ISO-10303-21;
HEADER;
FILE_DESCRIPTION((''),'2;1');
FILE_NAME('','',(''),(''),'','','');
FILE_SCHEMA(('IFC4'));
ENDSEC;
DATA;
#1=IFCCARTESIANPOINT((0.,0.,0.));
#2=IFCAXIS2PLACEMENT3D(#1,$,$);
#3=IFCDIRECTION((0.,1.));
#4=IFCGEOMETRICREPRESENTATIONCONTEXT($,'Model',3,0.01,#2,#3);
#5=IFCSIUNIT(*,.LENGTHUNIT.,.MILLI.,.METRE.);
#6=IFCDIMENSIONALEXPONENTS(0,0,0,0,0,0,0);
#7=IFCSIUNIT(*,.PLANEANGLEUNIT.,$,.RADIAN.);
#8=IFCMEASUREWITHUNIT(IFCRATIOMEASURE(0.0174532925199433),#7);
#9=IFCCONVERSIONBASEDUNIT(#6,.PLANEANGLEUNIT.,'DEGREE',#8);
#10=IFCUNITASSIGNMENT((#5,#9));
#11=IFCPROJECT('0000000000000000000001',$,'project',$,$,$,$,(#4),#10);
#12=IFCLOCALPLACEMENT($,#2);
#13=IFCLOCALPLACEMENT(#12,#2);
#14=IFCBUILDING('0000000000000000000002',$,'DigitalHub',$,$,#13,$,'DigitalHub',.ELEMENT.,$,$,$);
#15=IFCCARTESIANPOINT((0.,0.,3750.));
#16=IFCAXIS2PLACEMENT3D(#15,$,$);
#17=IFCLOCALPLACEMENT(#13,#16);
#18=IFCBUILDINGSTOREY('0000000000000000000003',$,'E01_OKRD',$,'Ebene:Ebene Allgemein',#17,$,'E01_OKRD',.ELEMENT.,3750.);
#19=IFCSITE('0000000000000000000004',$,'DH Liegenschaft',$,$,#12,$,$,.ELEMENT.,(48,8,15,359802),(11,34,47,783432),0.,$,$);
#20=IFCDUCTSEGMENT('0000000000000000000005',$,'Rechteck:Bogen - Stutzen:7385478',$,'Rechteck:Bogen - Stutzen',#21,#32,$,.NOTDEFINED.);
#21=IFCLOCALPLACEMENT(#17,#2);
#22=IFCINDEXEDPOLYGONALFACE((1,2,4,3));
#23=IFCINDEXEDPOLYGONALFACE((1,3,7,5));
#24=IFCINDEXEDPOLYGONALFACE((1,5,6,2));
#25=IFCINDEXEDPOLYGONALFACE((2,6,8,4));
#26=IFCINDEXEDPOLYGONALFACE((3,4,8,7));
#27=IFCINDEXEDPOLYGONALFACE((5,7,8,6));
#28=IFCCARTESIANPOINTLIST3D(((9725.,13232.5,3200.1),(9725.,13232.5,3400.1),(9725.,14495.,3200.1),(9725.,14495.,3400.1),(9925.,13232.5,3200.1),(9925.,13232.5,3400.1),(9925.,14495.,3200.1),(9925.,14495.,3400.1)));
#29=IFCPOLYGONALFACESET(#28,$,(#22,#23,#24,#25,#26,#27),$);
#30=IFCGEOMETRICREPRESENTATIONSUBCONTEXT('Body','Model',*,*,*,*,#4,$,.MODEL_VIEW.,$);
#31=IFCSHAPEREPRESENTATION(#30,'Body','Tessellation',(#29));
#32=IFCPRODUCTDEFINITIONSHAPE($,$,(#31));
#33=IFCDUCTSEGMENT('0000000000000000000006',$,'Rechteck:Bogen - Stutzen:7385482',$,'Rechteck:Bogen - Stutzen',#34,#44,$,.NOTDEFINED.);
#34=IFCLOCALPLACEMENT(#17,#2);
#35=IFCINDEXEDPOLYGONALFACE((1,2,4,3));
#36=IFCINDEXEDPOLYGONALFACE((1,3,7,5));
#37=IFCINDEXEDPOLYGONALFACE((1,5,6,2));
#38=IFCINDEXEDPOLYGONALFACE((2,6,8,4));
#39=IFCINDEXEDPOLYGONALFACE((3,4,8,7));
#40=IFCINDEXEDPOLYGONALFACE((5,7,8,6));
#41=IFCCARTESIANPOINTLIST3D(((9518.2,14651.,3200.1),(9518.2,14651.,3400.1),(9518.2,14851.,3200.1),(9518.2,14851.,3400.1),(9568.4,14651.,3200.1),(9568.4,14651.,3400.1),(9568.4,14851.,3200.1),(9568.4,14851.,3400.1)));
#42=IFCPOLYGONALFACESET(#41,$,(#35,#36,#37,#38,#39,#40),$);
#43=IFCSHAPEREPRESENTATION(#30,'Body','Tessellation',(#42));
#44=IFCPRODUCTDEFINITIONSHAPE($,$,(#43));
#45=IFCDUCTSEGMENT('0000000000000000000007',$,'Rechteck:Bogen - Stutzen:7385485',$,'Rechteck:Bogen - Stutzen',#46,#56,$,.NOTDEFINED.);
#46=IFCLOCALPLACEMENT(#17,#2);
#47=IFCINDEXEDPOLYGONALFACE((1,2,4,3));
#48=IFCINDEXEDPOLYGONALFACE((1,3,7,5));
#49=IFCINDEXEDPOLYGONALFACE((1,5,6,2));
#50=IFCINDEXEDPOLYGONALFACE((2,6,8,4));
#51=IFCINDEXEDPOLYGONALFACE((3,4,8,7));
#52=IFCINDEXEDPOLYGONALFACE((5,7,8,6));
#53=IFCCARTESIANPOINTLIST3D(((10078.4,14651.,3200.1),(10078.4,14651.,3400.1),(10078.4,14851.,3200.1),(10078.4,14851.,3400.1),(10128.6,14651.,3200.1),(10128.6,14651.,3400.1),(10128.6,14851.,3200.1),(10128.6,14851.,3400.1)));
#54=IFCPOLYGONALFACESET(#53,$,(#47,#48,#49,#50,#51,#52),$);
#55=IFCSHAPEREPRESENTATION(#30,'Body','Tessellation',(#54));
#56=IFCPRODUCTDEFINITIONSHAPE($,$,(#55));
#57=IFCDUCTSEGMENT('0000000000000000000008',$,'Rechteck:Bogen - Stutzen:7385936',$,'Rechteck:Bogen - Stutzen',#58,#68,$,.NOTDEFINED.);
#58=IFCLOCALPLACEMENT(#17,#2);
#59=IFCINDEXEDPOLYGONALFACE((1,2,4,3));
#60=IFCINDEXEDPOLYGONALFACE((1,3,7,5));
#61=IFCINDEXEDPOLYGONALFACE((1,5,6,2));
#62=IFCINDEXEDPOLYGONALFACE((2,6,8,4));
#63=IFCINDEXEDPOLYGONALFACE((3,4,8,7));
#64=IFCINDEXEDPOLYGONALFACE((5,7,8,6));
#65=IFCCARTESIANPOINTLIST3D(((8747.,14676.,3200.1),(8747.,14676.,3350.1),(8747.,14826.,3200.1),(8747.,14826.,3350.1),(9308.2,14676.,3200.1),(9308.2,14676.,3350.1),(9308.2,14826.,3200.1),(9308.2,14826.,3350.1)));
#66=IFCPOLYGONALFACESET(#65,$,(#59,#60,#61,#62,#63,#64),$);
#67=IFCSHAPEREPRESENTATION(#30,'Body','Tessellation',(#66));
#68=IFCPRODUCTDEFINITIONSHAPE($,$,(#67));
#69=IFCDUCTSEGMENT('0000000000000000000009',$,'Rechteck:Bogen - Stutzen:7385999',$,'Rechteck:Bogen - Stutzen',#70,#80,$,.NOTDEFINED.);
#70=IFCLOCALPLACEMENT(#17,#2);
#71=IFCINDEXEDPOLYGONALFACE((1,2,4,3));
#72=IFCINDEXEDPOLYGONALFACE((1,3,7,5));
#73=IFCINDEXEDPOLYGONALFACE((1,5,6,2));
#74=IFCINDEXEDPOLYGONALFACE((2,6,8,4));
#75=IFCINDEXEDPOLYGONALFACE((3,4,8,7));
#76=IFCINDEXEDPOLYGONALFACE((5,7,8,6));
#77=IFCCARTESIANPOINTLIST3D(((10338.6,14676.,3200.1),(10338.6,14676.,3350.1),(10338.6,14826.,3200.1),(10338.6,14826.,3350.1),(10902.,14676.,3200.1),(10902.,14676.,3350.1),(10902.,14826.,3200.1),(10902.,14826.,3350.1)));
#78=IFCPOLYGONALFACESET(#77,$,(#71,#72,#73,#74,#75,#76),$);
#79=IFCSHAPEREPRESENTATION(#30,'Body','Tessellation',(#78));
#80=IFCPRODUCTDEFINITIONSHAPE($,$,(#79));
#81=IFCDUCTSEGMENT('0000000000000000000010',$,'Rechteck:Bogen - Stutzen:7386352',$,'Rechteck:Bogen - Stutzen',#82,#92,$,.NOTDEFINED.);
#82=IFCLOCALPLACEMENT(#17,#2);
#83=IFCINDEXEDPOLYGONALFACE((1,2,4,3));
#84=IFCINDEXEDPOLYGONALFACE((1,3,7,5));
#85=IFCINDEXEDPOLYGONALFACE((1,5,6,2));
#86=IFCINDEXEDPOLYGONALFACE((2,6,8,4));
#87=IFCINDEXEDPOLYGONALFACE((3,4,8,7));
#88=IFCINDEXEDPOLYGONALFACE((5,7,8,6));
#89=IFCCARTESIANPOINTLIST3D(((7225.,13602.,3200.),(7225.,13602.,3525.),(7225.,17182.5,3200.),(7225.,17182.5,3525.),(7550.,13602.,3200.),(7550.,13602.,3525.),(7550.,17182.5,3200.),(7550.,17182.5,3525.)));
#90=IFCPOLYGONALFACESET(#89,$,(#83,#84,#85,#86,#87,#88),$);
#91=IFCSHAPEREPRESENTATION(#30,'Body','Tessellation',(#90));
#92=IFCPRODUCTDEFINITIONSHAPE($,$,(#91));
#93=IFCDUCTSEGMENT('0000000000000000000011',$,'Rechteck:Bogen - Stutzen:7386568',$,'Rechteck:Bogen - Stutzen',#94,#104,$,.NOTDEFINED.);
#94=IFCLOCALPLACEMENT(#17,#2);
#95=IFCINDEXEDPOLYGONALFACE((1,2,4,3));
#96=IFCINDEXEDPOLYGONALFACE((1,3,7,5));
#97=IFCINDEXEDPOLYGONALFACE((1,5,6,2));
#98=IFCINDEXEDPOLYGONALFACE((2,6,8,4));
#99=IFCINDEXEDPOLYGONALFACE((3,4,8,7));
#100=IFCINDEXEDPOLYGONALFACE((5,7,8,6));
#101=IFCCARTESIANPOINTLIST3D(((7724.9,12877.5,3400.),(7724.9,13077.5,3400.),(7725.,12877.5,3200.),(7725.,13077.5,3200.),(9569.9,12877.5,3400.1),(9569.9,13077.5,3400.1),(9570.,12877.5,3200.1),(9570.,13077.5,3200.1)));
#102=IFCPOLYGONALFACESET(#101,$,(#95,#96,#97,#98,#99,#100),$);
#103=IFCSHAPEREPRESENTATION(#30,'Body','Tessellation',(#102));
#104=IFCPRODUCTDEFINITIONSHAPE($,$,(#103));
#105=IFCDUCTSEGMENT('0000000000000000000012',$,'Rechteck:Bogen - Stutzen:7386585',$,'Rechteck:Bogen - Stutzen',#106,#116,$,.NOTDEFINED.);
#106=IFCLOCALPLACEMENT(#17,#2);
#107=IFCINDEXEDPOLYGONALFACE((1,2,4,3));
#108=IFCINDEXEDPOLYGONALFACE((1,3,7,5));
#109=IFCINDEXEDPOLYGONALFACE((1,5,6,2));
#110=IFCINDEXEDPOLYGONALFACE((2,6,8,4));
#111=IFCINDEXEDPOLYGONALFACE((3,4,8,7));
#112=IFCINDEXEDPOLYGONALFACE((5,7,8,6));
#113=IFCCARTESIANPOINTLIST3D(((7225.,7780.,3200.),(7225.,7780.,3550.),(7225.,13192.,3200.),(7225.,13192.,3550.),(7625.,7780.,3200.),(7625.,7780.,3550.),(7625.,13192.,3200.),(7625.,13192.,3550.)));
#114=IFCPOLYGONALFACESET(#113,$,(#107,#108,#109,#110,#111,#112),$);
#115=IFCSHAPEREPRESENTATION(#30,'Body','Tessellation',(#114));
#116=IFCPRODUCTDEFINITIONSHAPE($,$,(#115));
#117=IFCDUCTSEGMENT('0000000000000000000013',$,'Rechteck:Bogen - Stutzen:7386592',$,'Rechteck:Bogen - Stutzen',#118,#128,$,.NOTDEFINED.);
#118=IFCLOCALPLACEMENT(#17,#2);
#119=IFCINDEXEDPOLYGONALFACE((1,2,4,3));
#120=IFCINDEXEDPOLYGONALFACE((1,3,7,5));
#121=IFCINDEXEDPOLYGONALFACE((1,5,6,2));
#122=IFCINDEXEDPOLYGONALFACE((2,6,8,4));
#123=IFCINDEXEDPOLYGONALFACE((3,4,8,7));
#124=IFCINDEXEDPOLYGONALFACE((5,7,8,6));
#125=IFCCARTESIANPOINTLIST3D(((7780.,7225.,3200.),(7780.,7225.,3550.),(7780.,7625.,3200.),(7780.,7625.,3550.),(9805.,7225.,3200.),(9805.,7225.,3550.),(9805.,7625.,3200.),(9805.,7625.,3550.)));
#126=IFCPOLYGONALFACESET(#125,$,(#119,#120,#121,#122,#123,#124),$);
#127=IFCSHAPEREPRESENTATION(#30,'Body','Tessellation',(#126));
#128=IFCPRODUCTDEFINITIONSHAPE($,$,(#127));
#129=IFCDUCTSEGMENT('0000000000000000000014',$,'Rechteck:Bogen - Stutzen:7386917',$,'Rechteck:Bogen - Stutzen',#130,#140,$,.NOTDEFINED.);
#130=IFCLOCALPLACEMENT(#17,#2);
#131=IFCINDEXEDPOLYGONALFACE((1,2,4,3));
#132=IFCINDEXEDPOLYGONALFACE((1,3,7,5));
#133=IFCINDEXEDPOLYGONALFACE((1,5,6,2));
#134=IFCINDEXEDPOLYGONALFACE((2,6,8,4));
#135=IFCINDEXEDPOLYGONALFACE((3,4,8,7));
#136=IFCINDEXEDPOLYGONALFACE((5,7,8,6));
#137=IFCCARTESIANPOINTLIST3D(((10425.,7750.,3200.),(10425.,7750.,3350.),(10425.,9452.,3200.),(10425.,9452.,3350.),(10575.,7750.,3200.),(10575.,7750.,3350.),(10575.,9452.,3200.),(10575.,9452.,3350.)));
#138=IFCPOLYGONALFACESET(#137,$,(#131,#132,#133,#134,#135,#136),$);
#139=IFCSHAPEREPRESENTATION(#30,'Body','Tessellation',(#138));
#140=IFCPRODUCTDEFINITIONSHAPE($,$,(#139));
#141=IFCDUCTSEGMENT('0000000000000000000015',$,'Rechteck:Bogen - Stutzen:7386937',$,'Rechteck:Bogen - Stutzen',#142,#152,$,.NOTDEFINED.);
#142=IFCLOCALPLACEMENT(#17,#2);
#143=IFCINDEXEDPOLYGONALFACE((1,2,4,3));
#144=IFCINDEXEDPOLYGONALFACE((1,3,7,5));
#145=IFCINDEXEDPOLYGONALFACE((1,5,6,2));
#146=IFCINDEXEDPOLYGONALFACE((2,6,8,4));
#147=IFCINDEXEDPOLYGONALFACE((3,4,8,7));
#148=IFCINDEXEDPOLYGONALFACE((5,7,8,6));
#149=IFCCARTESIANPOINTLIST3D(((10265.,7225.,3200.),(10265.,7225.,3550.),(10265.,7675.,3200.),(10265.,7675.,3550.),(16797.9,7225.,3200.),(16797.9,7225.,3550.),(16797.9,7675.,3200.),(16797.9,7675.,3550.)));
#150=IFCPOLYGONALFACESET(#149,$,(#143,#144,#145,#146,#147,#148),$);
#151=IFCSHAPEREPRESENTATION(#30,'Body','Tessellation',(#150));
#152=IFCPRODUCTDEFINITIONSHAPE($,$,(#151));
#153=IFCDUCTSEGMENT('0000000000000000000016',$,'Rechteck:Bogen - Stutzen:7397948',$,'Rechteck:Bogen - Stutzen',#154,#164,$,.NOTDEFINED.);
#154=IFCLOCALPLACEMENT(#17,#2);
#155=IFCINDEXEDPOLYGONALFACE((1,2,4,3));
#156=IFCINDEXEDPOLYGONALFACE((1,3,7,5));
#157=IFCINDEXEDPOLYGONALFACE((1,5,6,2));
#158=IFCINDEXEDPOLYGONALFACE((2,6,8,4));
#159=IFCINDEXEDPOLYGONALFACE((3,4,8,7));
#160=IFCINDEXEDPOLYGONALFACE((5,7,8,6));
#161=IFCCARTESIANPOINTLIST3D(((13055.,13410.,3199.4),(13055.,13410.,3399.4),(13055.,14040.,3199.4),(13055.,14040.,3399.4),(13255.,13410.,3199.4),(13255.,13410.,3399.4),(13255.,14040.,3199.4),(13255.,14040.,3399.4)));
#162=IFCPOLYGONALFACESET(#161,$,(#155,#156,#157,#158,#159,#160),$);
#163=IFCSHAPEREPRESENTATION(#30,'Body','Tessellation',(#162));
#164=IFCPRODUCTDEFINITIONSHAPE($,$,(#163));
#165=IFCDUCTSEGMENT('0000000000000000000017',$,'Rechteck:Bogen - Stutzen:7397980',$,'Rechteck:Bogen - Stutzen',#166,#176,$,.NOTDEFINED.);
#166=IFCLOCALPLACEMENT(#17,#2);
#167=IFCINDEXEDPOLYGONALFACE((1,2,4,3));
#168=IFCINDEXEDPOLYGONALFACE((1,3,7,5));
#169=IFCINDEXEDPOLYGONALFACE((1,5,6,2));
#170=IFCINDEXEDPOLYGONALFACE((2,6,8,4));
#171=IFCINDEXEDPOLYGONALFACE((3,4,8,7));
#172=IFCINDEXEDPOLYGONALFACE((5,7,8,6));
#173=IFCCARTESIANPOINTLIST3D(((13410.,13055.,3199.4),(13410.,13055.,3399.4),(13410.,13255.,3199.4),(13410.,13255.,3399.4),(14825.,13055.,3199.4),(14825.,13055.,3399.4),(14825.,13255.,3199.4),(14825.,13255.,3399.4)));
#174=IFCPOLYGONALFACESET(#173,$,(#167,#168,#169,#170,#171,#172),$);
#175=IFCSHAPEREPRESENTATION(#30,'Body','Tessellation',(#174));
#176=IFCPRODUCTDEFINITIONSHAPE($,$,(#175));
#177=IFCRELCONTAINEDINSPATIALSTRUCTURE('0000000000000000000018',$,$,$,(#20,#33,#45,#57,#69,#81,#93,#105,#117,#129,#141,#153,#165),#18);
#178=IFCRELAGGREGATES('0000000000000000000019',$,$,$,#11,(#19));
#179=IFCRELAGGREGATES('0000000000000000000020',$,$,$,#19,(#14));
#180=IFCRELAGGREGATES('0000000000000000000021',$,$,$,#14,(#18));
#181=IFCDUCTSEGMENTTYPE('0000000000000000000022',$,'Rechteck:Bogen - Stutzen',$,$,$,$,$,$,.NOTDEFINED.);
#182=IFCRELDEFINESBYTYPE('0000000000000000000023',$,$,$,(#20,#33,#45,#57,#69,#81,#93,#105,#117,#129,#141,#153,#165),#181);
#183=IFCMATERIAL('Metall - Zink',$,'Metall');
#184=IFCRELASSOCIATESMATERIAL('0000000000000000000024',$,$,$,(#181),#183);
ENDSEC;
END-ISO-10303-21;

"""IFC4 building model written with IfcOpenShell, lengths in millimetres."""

from ifc_helpers import new_model, entity, si_unit, converted_unit, direction, frame, origin, place, context, subcontext, project, spatial, indexed_curve, outline, extrude, material, type_object, element, save


model = new_model("IFC4")

# Units and contexts
model_context = context("Model", 3, precision=0.01, world=origin(), true_north=direction((0.0, 1.0)))
body_context = subcontext(model_context, "Body", "Model", "MODEL_VIEW")
ifc_project = project(units=[si_unit("LENGTHUNIT", "METRE", prefix="MILLI"), converted_unit("PLANEANGLEUNIT", "DEGREE", entity("IfcRatioMeasure", 0.0174532925199433), si_unit("PLANEANGLEUNIT", "RADIAN"), dimensions=[0, 0, 0, 0, 0, 0, 0])], contexts=[model_context])

# Site, building, storey
site_placement = place(None, origin())
site = spatial("IfcSite", under=ifc_project, at=site_placement, Name="DH Liegenschaft", CompositionType="ELEMENT", RefLatitude=(48, 8, 15, 359802), RefLongitude=(11, 34, 47, 783432), RefElevation=0.0)
building_placement = place(site_placement, origin())
building = spatial("IfcBuilding", under=site, at=building_placement, Name="DigitalHub", LongName="DigitalHub", CompositionType="ELEMENT")
storey_placement = place(building_placement, frame((0.0, 0.0, 3750.0)))
storey = spatial("IfcBuildingStorey", under=building, at=storey_placement, Name="E01_OKRD", ObjectType="Ebene:Ebene Allgemein", LongName="E01_OKRD", CompositionType="ELEMENT", Elevation=3750.0)

# Duct segments
ifc_material_1 = material(Name="Metall - Zink", Category="Metall")
duct_segment_type_1 = type_object("IfcDuctSegmentType", Name="Rechteck:Bogen - Stutzen", PredefinedType="NOTDEFINED", material=ifc_material_1)
duct_segment_1_placement = place(storey_placement, frame((9725.0, 13232.5, 3200.1)))
element("IfcDuctSegment", 1, at=duct_segment_1_placement, inside=storey, type_object=duct_segment_type_1, Name="Rechteck:Bogen - Stutzen:7385478", ObjectType="Rechteck:Bogen - Stutzen", PredefinedType="NOTDEFINED", context=body_context, shape_type="SweptSolid", body=[
    extrude(outline(indexed_curve([(-631.3, -100.0), (631.3, -100.0), (631.3, 100.0), (-631.3, 100.0), (-631.3, -100.0)], self_intersect=False)), frame((100.0, 631.3, 0.0), z_axis=(0.0, 0.0, 1.0), x_axis=(0.0, 1.0, 0.0)), (0.0, 0.0, 1.0), 200.0),
])
duct_segment_2_placement = place(storey_placement, frame((9518.2, 14651.0, 3200.1)))
element("IfcDuctSegment", 2, at=duct_segment_2_placement, inside=storey, type_object=duct_segment_type_1, Name="Rechteck:Bogen - Stutzen:7385482", ObjectType="Rechteck:Bogen - Stutzen", PredefinedType="NOTDEFINED", context=body_context, shape_type="SweptSolid", body=[
    extrude(outline(indexed_curve([(-25.1, -100.0), (25.1, -100.0), (25.1, 100.0), (-25.1, 100.0), (-25.1, -100.0)], self_intersect=False)), frame((25.1, 100.0, 0.0), z_axis=(0.0, 0.0, 1.0), x_axis=(-1.0, 0.0, 0.0)), (0.0, 0.0, 1.0), 200.0),
])
duct_segment_3_placement = place(storey_placement, frame((10078.4, 14651.0, 3200.1)))
element("IfcDuctSegment", 3, at=duct_segment_3_placement, inside=storey, type_object=duct_segment_type_1, Name="Rechteck:Bogen - Stutzen:7385485", ObjectType="Rechteck:Bogen - Stutzen", PredefinedType="NOTDEFINED", context=body_context, shape_type="SweptSolid", body=[
    extrude(outline(indexed_curve([(-25.1, -100.0), (25.1, -100.0), (25.1, 100.0), (-25.1, 100.0), (-25.1, -100.0)], self_intersect=False)), frame((25.1, 100.0, 0.0)), (0.0, 0.0, 1.0), 200.0),
])
duct_segment_4_placement = place(storey_placement, frame((8747.0, 14676.0, 3200.1)))
element("IfcDuctSegment", 4, at=duct_segment_4_placement, inside=storey, type_object=duct_segment_type_1, Name="Rechteck:Bogen - Stutzen:7385936", ObjectType="Rechteck:Bogen - Stutzen", PredefinedType="NOTDEFINED", context=body_context, shape_type="SweptSolid", body=[
    extrude(outline(indexed_curve([(-280.6, -75.0), (280.6, -75.0), (280.6, 75.0), (-280.6, 75.0), (-280.6, -75.0)], self_intersect=False)), frame((280.6, 75.0, 0.0)), (0.0, 0.0, 1.0), 150.0),
])
duct_segment_5_placement = place(storey_placement, frame((10338.6, 14676.0, 3200.1)))
element("IfcDuctSegment", 5, at=duct_segment_5_placement, inside=storey, type_object=duct_segment_type_1, Name="Rechteck:Bogen - Stutzen:7385999", ObjectType="Rechteck:Bogen - Stutzen", PredefinedType="NOTDEFINED", context=body_context, shape_type="SweptSolid", body=[
    extrude(outline(indexed_curve([(-281.7, -75.0), (281.7, -75.0), (281.7, 75.0), (-281.7, 75.0), (-281.7, -75.0)], self_intersect=False)), frame((281.7, 75.0, 0.0), z_axis=(0.0, 0.0, 1.0), x_axis=(-1.0, 0.0, 0.0)), (0.0, 0.0, 1.0), 150.0),
])
duct_segment_6_placement = place(storey_placement, frame((7225.0, 13602.0, 3200.0)))
element("IfcDuctSegment", 6, at=duct_segment_6_placement, inside=storey, type_object=duct_segment_type_1, Name="Rechteck:Bogen - Stutzen:7386352", ObjectType="Rechteck:Bogen - Stutzen", PredefinedType="NOTDEFINED", context=body_context, shape_type="SweptSolid", body=[
    extrude(outline(indexed_curve([(-1790.2, -162.5), (1790.2, -162.5), (1790.2, 162.5), (-1790.2, 162.5), (-1790.2, -162.5)], self_intersect=False)), frame((162.5, 1790.2, 0.0), z_axis=(0.0, 0.0, 1.0), x_axis=(0.0, -1.0, 0.0)), (0.0, 0.0, 1.0), 325.0),
])
duct_segment_7_placement = place(storey_placement, frame((7724.9, 12877.5, 3200.0)))
element("IfcDuctSegment", 7, at=duct_segment_7_placement, inside=storey, type_object=duct_segment_type_1, Name="Rechteck:Bogen - Stutzen:7386568", ObjectType="Rechteck:Bogen - Stutzen", PredefinedType="NOTDEFINED", context=body_context, shape_type="SweptSolid", body=[
    extrude(outline(indexed_curve([(-922.5, -100.0), (922.5, -100.0), (922.5, 100.0), (-922.5, 100.0), (-922.5, -100.0)], self_intersect=False)), frame((922.5, 100.0, 0.1), z_axis=(-0.000079, 0.0, 1.0), x_axis=(1.0, 0.0, 0.000079)), (0.0, 0.0, 1.0), 200.0),
])
duct_segment_8_placement = place(storey_placement, frame((7225.0, 7780.0, 3200.0)))
element("IfcDuctSegment", 8, at=duct_segment_8_placement, inside=storey, type_object=duct_segment_type_1, Name="Rechteck:Bogen - Stutzen:7386585", ObjectType="Rechteck:Bogen - Stutzen", PredefinedType="NOTDEFINED", context=body_context, shape_type="SweptSolid", body=[
    extrude(outline(indexed_curve([(-2706.0, -200.0), (2706.0, -200.0), (2706.0, 200.0), (-2706.0, 200.0), (-2706.0, -200.0)], self_intersect=False)), frame((200.0, 2706.0, 0.0), z_axis=(0.0, 0.0, 1.0), x_axis=(0.0, -1.0, 0.0)), (0.0, 0.0, 1.0), 350.0),
])
duct_segment_9_placement = place(storey_placement, frame((7780.0, 7225.0, 3200.0)))
element("IfcDuctSegment", 9, at=duct_segment_9_placement, inside=storey, type_object=duct_segment_type_1, Name="Rechteck:Bogen - Stutzen:7386592", ObjectType="Rechteck:Bogen - Stutzen", PredefinedType="NOTDEFINED", context=body_context, shape_type="SweptSolid", body=[
    extrude(outline(indexed_curve([(-1012.5, -200.0), (1012.5, -200.0), (1012.5, 200.0), (-1012.5, 200.0), (-1012.5, -200.0)], self_intersect=False)), frame((1012.5, 200.0, 0.0)), (0.0, 0.0, 1.0), 350.0),
])
duct_segment_10_placement = place(storey_placement, frame((10425.0, 7750.0, 3200.0)))
element("IfcDuctSegment", 10, at=duct_segment_10_placement, inside=storey, type_object=duct_segment_type_1, Name="Rechteck:Bogen - Stutzen:7386917", ObjectType="Rechteck:Bogen - Stutzen", PredefinedType="NOTDEFINED", context=body_context, shape_type="SweptSolid", body=[
    extrude(outline(indexed_curve([(-851.0, -75.0), (851.0, -75.0), (851.0, 75.0), (-851.0, 75.0), (-851.0, -75.0)], self_intersect=False)), frame((75.0, 851.0, 0.0), z_axis=(0.0, 0.0, 1.0), x_axis=(0.0, -1.0, 0.0)), (0.0, 0.0, 1.0), 150.0),
])
duct_segment_11_placement = place(storey_placement, frame((10265.0, 7225.0, 3200.0)))
element("IfcDuctSegment", 11, at=duct_segment_11_placement, inside=storey, type_object=duct_segment_type_1, Name="Rechteck:Bogen - Stutzen:7386937", ObjectType="Rechteck:Bogen - Stutzen", PredefinedType="NOTDEFINED", context=body_context, shape_type="SweptSolid", body=[
    extrude(outline(indexed_curve([(-3266.5, -225.0), (3266.5, -225.0), (3266.5, 225.0), (-3266.5, 225.0), (-3266.5, -225.0)], self_intersect=False)), frame((3266.5, 225.0, 0.0)), (0.0, 0.0, 1.0), 350.0),
])
duct_segment_12_placement = place(storey_placement, frame((13055.0, 13410.0, 3199.4)))
element("IfcDuctSegment", 12, at=duct_segment_12_placement, inside=storey, type_object=duct_segment_type_1, Name="Rechteck:Bogen - Stutzen:7397948", ObjectType="Rechteck:Bogen - Stutzen", PredefinedType="NOTDEFINED", context=body_context, shape_type="SweptSolid", body=[
    extrude(outline(indexed_curve([(-315.0, -100.0), (315.0, -100.0), (315.0, 100.0), (-315.0, 100.0), (-315.0, -100.0)], self_intersect=False)), frame((100.0, 315.0, 0.0), z_axis=(0.0, 0.0, 1.0), x_axis=(0.0, 1.0, 0.0)), (0.0, 0.0, 1.0), 200.0),
])
duct_segment_13_placement = place(storey_placement, frame((13410.0, 13055.0, 3199.4)))
element("IfcDuctSegment", 13, at=duct_segment_13_placement, inside=storey, type_object=duct_segment_type_1, Name="Rechteck:Bogen - Stutzen:7397980", ObjectType="Rechteck:Bogen - Stutzen", PredefinedType="NOTDEFINED", context=body_context, shape_type="SweptSolid", body=[
    extrude(outline(indexed_curve([(-707.5, -100.0), (707.5, -100.0), (707.5, 100.0), (-707.5, 100.0), (-707.5, -100.0)], self_intersect=False)), frame((707.5, 100.0, 0.0), z_axis=(0.0, 0.0, 1.0), x_axis=(-1.0, 0.0, 0.0)), (0.0, 0.0, 1.0), 200.0),
])

save(model, "model.ifc")
